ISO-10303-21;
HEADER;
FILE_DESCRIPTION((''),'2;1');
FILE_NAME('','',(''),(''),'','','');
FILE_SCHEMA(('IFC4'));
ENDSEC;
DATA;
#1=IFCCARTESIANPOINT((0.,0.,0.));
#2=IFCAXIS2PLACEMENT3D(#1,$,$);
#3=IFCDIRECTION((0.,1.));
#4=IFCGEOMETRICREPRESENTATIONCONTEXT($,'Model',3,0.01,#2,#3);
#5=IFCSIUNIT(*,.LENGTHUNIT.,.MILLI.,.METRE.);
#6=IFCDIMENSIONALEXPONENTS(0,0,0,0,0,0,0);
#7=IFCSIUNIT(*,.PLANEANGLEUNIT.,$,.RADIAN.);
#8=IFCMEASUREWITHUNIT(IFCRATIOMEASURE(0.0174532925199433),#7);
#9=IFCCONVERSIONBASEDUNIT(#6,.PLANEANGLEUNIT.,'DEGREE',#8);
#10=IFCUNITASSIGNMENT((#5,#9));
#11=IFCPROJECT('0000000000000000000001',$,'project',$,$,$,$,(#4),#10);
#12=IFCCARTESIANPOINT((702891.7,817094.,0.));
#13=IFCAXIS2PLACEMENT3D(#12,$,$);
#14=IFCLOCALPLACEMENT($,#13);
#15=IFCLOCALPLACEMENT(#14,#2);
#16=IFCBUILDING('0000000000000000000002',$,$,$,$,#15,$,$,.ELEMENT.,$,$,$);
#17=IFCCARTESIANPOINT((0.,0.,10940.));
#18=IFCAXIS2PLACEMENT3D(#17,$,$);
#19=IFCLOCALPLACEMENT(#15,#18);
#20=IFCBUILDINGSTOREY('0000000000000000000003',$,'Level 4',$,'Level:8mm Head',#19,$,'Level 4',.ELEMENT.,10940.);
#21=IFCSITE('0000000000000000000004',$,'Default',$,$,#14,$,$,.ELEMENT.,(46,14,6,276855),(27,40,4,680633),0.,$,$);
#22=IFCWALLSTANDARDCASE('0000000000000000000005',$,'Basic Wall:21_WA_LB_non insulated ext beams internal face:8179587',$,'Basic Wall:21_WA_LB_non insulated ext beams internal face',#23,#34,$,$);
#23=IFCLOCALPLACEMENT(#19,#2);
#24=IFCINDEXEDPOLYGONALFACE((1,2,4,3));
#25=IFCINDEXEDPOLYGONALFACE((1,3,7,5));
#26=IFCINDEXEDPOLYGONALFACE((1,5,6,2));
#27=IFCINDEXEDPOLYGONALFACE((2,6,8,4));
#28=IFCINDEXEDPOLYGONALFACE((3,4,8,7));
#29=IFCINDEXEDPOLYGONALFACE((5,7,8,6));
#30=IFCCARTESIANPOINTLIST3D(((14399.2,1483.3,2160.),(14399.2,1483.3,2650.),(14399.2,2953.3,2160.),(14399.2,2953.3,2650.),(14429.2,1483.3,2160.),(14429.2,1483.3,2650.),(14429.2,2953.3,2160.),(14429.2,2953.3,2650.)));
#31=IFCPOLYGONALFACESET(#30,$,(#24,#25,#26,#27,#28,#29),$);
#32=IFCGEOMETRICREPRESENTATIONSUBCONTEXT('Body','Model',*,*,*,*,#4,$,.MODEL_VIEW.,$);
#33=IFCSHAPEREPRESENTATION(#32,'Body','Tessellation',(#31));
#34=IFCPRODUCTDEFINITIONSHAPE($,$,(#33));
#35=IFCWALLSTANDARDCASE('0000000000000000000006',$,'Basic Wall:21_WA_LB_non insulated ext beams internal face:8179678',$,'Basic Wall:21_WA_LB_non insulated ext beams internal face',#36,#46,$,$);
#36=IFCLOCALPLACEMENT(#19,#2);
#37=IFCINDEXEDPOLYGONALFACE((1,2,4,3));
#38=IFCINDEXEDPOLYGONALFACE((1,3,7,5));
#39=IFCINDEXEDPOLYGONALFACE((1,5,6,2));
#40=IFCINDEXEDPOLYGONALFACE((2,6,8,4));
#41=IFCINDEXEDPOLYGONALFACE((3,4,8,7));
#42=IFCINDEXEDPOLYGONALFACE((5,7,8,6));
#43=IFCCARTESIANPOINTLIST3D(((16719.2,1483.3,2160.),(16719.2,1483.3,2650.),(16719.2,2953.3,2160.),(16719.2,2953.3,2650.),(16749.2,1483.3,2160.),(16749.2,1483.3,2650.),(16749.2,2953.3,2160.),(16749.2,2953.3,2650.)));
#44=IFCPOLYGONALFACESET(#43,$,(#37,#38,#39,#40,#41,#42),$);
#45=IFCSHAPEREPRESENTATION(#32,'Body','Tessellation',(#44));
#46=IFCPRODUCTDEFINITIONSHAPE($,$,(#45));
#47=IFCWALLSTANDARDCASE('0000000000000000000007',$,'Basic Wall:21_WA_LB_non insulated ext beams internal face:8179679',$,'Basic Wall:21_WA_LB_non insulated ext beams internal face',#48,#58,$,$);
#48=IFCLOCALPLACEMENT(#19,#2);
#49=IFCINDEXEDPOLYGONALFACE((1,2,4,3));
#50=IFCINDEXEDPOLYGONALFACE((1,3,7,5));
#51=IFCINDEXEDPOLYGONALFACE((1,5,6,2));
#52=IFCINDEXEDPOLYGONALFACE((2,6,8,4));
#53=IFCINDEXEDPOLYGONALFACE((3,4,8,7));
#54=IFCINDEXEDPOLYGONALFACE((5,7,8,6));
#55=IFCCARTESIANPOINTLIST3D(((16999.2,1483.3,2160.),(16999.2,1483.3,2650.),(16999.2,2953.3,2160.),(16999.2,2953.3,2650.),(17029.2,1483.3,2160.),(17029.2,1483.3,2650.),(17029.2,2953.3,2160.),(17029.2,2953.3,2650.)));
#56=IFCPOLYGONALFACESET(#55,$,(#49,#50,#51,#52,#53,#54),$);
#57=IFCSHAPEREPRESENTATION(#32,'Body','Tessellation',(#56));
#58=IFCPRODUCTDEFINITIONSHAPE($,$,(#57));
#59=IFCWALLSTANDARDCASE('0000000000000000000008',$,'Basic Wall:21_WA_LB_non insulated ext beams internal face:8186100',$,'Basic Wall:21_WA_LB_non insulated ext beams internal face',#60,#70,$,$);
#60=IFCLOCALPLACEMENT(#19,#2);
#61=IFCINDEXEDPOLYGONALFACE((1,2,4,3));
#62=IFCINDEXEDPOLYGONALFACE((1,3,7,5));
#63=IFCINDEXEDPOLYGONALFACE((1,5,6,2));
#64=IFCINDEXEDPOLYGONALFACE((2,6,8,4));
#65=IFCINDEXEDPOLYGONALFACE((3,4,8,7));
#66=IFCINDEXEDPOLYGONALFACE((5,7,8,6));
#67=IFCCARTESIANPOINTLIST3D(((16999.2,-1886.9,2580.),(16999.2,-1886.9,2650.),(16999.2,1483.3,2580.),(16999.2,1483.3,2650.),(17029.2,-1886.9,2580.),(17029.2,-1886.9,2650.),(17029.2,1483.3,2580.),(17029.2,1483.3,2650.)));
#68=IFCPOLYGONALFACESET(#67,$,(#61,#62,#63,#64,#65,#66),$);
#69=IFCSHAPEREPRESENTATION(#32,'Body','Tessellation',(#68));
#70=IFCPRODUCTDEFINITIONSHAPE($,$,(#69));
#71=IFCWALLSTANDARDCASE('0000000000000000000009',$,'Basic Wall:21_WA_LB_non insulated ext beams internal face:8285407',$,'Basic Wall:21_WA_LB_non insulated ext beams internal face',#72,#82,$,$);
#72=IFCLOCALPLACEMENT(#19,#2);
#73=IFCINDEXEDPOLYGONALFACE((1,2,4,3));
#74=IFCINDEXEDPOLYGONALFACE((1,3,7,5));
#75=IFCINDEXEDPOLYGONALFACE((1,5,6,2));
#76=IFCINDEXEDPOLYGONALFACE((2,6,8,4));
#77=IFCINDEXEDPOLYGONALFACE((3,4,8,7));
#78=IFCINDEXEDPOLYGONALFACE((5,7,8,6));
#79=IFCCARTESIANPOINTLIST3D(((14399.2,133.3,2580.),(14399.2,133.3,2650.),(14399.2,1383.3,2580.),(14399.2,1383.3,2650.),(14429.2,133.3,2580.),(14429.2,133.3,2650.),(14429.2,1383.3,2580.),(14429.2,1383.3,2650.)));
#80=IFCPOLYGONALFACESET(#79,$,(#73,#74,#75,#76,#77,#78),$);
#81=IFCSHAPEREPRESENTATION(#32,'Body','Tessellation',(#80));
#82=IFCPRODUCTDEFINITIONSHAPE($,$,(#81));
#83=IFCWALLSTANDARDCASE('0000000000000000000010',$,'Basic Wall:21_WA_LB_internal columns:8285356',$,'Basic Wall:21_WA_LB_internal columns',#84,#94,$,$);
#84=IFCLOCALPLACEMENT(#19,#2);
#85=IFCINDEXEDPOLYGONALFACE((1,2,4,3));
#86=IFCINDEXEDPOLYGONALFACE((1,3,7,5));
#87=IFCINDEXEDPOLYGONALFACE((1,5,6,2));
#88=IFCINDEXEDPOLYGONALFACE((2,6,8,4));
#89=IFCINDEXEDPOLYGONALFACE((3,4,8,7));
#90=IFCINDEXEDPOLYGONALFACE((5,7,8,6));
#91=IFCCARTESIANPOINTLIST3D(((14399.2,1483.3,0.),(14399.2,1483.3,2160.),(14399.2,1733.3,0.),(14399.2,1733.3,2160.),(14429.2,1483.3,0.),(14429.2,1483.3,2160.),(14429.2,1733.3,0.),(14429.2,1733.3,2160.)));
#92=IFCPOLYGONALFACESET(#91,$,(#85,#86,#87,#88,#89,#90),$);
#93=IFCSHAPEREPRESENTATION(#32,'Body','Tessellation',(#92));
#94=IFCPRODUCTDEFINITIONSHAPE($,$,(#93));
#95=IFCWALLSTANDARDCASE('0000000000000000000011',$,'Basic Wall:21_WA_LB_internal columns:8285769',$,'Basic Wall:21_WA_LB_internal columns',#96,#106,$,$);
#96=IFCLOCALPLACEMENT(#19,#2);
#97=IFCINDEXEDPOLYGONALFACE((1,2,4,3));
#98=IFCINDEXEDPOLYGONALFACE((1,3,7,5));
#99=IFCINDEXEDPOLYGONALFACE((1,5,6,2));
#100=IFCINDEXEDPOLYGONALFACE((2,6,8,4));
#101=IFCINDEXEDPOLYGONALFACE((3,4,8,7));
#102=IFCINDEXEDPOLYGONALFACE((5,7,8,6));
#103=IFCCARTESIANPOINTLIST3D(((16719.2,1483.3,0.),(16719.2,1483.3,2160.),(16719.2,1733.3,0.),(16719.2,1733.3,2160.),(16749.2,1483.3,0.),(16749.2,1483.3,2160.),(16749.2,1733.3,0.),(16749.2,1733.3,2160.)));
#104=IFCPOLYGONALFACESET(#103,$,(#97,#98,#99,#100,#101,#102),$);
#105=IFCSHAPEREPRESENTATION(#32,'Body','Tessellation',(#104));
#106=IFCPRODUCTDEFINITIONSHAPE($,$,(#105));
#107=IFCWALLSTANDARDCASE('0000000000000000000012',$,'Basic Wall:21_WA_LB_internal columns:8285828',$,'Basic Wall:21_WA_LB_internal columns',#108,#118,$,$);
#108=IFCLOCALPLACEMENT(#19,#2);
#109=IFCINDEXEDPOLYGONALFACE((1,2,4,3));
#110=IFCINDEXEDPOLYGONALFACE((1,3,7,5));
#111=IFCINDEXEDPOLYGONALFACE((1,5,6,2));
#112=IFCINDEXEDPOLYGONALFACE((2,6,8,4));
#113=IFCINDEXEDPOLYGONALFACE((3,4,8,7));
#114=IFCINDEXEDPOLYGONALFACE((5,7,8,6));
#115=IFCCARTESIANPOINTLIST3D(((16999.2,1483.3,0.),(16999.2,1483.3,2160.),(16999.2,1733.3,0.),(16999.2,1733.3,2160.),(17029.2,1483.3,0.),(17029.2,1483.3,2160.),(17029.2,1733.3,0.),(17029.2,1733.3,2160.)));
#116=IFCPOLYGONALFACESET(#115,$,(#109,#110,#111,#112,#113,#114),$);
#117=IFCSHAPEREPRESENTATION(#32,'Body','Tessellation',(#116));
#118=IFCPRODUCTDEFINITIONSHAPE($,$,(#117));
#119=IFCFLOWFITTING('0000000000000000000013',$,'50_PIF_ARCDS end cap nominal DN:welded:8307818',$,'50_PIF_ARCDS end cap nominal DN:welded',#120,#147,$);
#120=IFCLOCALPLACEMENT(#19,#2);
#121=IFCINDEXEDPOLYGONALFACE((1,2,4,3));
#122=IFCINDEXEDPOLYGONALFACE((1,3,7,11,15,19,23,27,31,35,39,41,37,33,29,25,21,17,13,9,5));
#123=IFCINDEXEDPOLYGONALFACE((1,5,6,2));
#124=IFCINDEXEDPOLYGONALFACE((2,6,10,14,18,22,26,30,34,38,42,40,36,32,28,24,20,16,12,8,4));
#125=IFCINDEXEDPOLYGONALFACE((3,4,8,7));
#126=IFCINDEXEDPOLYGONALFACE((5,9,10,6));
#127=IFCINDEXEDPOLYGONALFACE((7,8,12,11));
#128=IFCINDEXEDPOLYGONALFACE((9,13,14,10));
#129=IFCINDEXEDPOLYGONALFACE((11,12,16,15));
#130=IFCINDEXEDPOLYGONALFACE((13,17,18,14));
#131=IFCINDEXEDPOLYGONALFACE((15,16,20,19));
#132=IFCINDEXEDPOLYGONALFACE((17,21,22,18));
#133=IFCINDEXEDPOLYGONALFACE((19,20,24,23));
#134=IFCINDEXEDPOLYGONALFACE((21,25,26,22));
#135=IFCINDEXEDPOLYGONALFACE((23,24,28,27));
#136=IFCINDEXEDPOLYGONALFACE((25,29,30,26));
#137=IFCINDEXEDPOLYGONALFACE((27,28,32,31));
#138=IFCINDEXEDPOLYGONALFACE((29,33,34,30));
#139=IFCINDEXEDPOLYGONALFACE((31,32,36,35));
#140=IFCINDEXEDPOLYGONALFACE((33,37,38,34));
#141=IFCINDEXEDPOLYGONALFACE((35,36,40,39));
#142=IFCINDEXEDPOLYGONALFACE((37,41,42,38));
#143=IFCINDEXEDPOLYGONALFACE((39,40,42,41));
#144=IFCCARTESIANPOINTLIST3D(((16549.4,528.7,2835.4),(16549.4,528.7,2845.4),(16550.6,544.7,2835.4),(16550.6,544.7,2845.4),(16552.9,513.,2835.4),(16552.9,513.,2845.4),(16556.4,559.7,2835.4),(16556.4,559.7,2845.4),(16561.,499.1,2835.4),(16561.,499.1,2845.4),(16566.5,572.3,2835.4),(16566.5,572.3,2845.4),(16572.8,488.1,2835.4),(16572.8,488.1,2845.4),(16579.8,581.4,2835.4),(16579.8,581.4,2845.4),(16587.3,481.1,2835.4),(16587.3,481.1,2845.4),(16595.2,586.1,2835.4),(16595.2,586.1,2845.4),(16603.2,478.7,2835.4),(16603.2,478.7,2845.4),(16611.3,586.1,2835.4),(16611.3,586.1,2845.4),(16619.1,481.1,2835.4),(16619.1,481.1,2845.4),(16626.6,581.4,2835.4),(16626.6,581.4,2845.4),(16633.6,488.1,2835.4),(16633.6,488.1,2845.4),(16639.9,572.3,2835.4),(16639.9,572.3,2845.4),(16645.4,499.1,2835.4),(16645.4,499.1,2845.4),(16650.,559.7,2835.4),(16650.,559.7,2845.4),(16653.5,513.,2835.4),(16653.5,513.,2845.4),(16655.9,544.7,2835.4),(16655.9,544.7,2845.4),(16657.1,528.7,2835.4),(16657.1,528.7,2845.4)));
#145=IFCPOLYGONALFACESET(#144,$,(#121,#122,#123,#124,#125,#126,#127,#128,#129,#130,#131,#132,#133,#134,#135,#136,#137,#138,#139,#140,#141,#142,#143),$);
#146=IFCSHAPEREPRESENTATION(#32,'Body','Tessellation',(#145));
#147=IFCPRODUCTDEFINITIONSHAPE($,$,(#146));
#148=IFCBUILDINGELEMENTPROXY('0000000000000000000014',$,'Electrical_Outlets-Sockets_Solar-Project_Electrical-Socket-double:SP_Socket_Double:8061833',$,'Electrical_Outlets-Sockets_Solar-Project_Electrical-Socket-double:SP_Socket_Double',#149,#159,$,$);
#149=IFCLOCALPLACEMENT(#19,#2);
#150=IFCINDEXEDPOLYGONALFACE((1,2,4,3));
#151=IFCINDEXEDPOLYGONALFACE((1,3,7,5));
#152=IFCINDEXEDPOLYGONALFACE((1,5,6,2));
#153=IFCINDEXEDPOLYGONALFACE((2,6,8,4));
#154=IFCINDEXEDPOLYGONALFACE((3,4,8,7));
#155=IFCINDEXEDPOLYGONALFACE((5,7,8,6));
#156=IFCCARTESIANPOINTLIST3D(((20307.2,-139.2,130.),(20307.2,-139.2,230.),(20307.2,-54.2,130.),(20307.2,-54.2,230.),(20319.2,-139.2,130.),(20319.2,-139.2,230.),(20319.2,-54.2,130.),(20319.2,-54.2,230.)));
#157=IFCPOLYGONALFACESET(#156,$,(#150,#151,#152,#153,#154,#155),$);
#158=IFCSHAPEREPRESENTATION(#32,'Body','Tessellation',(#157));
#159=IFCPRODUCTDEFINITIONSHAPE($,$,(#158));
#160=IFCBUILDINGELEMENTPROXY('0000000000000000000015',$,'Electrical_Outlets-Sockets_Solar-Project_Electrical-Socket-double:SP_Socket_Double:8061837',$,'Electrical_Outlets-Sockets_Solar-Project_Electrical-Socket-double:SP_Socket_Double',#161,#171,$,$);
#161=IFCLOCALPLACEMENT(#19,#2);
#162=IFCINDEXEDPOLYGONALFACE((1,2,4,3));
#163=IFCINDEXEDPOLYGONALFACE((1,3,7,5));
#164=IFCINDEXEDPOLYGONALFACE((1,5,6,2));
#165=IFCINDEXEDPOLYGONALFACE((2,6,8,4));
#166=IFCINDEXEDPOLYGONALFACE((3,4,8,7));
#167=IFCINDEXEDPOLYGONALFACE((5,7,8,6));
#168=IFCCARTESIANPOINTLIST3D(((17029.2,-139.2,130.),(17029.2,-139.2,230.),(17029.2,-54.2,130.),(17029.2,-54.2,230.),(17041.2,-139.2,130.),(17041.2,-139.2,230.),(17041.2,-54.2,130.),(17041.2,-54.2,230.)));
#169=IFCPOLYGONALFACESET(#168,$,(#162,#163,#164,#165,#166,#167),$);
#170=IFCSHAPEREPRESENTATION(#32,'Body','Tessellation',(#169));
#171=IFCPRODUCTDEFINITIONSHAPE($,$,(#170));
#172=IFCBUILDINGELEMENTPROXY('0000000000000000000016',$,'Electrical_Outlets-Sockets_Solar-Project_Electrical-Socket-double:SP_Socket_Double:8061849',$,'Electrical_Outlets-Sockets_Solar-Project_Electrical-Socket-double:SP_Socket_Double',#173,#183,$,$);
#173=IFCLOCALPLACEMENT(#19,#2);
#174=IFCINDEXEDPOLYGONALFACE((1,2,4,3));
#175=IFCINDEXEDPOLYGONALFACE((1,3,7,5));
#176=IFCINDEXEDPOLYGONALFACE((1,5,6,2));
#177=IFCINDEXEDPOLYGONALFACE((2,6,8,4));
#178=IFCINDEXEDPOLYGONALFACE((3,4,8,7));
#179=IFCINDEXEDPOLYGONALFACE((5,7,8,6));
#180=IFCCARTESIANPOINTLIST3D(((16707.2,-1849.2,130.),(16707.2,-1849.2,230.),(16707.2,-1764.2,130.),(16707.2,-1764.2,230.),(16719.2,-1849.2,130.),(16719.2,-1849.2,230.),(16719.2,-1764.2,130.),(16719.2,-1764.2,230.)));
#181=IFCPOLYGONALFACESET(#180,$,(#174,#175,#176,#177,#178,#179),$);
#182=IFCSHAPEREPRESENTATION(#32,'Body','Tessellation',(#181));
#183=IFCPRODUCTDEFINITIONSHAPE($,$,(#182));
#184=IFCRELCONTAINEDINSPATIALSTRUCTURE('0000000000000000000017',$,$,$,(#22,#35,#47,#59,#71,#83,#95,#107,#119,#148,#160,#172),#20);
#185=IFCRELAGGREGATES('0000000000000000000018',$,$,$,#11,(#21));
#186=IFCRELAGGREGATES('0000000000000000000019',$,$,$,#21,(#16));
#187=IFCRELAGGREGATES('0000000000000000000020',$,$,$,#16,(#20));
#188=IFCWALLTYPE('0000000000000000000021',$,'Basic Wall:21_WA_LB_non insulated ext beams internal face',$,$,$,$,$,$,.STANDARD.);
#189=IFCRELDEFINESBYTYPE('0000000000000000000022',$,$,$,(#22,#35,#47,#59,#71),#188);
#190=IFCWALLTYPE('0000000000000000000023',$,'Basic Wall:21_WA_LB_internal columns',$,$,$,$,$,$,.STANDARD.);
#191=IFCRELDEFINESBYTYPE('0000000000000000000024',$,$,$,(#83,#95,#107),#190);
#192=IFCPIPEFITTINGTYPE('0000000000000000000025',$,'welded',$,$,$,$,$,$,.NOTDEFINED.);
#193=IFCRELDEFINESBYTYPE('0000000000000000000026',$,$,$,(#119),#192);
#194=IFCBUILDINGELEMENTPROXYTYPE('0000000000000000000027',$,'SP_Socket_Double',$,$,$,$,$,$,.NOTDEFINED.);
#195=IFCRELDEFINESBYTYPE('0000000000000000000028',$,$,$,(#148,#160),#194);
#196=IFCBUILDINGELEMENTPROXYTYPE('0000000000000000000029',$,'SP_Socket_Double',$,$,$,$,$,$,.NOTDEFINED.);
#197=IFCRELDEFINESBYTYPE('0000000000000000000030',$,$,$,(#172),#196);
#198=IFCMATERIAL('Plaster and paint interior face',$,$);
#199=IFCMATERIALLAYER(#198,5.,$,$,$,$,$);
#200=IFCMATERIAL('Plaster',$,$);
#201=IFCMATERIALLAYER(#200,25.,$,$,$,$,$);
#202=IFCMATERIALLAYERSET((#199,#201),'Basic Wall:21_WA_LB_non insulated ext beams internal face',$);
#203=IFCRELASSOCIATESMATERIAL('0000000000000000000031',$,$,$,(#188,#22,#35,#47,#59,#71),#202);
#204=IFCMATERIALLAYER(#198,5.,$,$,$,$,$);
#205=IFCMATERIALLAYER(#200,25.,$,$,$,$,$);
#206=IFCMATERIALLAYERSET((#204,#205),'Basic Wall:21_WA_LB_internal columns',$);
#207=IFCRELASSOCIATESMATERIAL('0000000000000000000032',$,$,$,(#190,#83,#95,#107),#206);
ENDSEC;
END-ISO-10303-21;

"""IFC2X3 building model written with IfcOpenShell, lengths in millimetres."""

from ifc_helpers import new_model, entity, si_unit, converted_unit, direction, frame, frame_2d, origin, origin_2d_with_axis, place, context, subcontext, project, spatial, rectangle, circle, extrude, source, transform, mapped, material, layer, layer_set, layer_usage, type_object, type_shapes, element, save


model = new_model("IFC2X3")

# Units and contexts
model_context = context("Model", 3, precision=0.01, world=origin(), true_north=direction((0.0, 1.0)))
body_context = subcontext(model_context, "Body", "Model", "MODEL_VIEW")
ifc_project = project(units=[si_unit("LENGTHUNIT", "METRE", prefix="MILLI"), converted_unit("PLANEANGLEUNIT", "DEGREE", entity("IfcRatioMeasure", 0.0174532925199433), si_unit("PLANEANGLEUNIT", "RADIAN"), dimensions=[0, 0, 0, 0, 0, 0, 0])], contexts=[model_context])

# Site, building, storey
site_placement = place(None, frame((702891.7, 817094.0, 0.0)))
site = spatial("IfcSite", under=ifc_project, at=site_placement, Name="Default", CompositionType="ELEMENT", RefLatitude=(46, 14, 6, 276855), RefLongitude=(27, 40, 4, 680633), RefElevation=0.0)
building_placement = place(site_placement, origin())
building = spatial("IfcBuilding", under=site, at=building_placement, CompositionType="ELEMENT")
storey_placement = place(building_placement, frame((0.0, 0.0, 10940.0)))
storey = spatial("IfcBuildingStorey", under=building, at=storey_placement, Name="Level 4", ObjectType="Level:8mm Head", LongName="Level 4", CompositionType="ELEMENT", Elevation=10940.0)

# Shared definitions
ifc_material_1 = material(Name="Plaster and paint interior face")
ifc_material_2 = material(Name="Plaster")

# Walls
ifc_layer_1 = layer(ifc_material_1, 5.0)
ifc_layer_2 = layer(ifc_material_2, 25.0)
ifc_layer_set_1 = layer_set([ifc_layer_1, ifc_layer_2], Name="Basic Wall:21_WA_LB_non insulated ext beams internal face")
wall_type_1 = type_object("IfcWallType", Name="Basic Wall:21_WA_LB_non insulated ext beams internal face", PredefinedType="STANDARD", material=ifc_layer_set_1)
ifc_layer_usage_1 = layer_usage(ifc_layer_set_1, "AXIS2", "POSITIVE", -15.0)
wall_1_placement = place(storey_placement, frame((14414.2, 1483.3, 2160.0), z_axis=(0.0, 0.0, 1.0), x_axis=(0.0, 1.0, 0.0)))
element("IfcWallStandardCase", 1, at=wall_1_placement, inside=storey, type_object=wall_type_1, material=ifc_layer_usage_1, Name="Basic Wall:21_WA_LB_non insulated ext beams internal face:8179587", ObjectType="Basic Wall:21_WA_LB_non insulated ext beams internal face", context=body_context, shape_type="SweptSolid", body=[
    extrude(rectangle(XDim=1470.0, YDim=30.0, at=frame_2d((735.0, 0.0), x_axis=(-1.0, 0.0))), origin(), (0.0, 0.0, 1.0), 490.0),
])
ifc_layer_usage_2 = layer_usage(ifc_layer_set_1, "AXIS2", "NEGATIVE", 15.0)
wall_2_placement = place(storey_placement, frame((16734.2, 1483.3, 2160.0), z_axis=(0.0, 0.0, 1.0), x_axis=(0.0, 1.0, 0.0)))
element("IfcWallStandardCase", 2, at=wall_2_placement, inside=storey, type_object=wall_type_1, material=ifc_layer_usage_2, Name="Basic Wall:21_WA_LB_non insulated ext beams internal face:8179678", ObjectType="Basic Wall:21_WA_LB_non insulated ext beams internal face", context=body_context, shape_type="SweptSolid", body=[
    extrude(rectangle(XDim=1470.0, YDim=30.0, at=frame_2d((735.0, 0.0), x_axis=(-1.0, 0.0))), origin(), (0.0, 0.0, 1.0), 490.0),
])
ifc_layer_usage_3 = layer_usage(ifc_layer_set_1, "AXIS2", "POSITIVE", -15.0)
wall_3_placement = place(storey_placement, frame((17014.2, 1483.3, 2160.0), z_axis=(0.0, 0.0, 1.0), x_axis=(0.0, 1.0, 0.0)))
element("IfcWallStandardCase", 3, at=wall_3_placement, inside=storey, type_object=wall_type_1, material=ifc_layer_usage_3, Name="Basic Wall:21_WA_LB_non insulated ext beams internal face:8179679", ObjectType="Basic Wall:21_WA_LB_non insulated ext beams internal face", context=body_context, shape_type="SweptSolid", body=[
    extrude(rectangle(XDim=1470.0, YDim=30.0, at=frame_2d((735.0, 0.0), x_axis=(-1.0, 0.0))), origin(), (0.0, 0.0, 1.0), 490.0),
])
ifc_layer_usage_4 = layer_usage(ifc_layer_set_1, "AXIS2", "NEGATIVE", 15.0)
wall_4_placement = place(storey_placement, frame((17014.2, 1483.3, 2580.0), z_axis=(0.0, 0.0, 1.0), x_axis=(0.0, -1.0, 0.0)))
element("IfcWallStandardCase", 4, at=wall_4_placement, inside=storey, type_object=wall_type_1, material=ifc_layer_usage_4, Name="Basic Wall:21_WA_LB_non insulated ext beams internal face:8186100", ObjectType="Basic Wall:21_WA_LB_non insulated ext beams internal face", context=body_context, shape_type="SweptSolid", body=[
    extrude(rectangle(XDim=3370.2, YDim=30.0, at=frame_2d((1685.1, 0.0), x_axis=(-1.0, 0.0))), origin(), (0.0, 0.0, 1.0), 70.0),
])
ifc_layer_usage_5 = layer_usage(ifc_layer_set_1, "AXIS2", "POSITIVE", -15.0)
wall_5_placement = place(storey_placement, frame((14414.2, 133.3, 2580.0), z_axis=(0.0, 0.0, 1.0), x_axis=(0.0, 1.0, 0.0)))
element("IfcWallStandardCase", 5, at=wall_5_placement, inside=storey, type_object=wall_type_1, material=ifc_layer_usage_5, Name="Basic Wall:21_WA_LB_non insulated ext beams internal face:8285407", ObjectType="Basic Wall:21_WA_LB_non insulated ext beams internal face", context=body_context, shape_type="SweptSolid", body=[
    extrude(rectangle(XDim=1250.0, YDim=30.0, at=frame_2d((625.0, 0.0), x_axis=(-1.0, 0.0))), origin(), (0.0, 0.0, 1.0), 70.0),
])
ifc_layer_3 = layer(ifc_material_1, 5.0)
ifc_layer_4 = layer(ifc_material_2, 25.0)
ifc_layer_set_2 = layer_set([ifc_layer_3, ifc_layer_4], Name="Basic Wall:21_WA_LB_internal columns")
ifc_layer_usage_6 = layer_usage(ifc_layer_set_2, "AXIS2", "NEGATIVE", 15.0)
wall_type_2 = type_object("IfcWallType", Name="Basic Wall:21_WA_LB_internal columns", PredefinedType="STANDARD", material=ifc_layer_set_2)
wall_6_placement = place(storey_placement, frame((14414.2, 1733.3, 0.0), z_axis=(0.0, 0.0, 1.0), x_axis=(0.0, -1.0, 0.0)))
element("IfcWallStandardCase", 6, at=wall_6_placement, inside=storey, type_object=wall_type_2, material=ifc_layer_usage_6, Name="Basic Wall:21_WA_LB_internal columns:8285356", ObjectType="Basic Wall:21_WA_LB_internal columns", context=body_context, shape_type="SweptSolid", body=[
    extrude(rectangle(XDim=250.0, YDim=30.0, at=frame_2d((125.0, 0.0), x_axis=(-1.0, 0.0))), origin(), (0.0, 0.0, 1.0), 2160.0),
])
ifc_layer_usage_7 = layer_usage(ifc_layer_set_2, "AXIS2", "POSITIVE", -15.0)
wall_7_placement = place(storey_placement, frame((16734.2, 1733.3, 0.0), z_axis=(0.0, 0.0, 1.0), x_axis=(0.0, -1.0, 0.0)))
element("IfcWallStandardCase", 7, at=wall_7_placement, inside=storey, type_object=wall_type_2, material=ifc_layer_usage_7, Name="Basic Wall:21_WA_LB_internal columns:8285769", ObjectType="Basic Wall:21_WA_LB_internal columns", context=body_context, shape_type="SweptSolid", body=[
    extrude(rectangle(XDim=250.0, YDim=30.0, at=frame_2d((125.0, 0.0), x_axis=(-1.0, 0.0))), origin(), (0.0, 0.0, 1.0), 2160.0),
])
ifc_layer_usage_8 = layer_usage(ifc_layer_set_2, "AXIS2", "NEGATIVE", 15.0)
wall_8_placement = place(storey_placement, frame((17014.2, 1733.3, 0.0), z_axis=(0.0, 0.0, 1.0), x_axis=(0.0, -1.0, 0.0)))
element("IfcWallStandardCase", 8, at=wall_8_placement, inside=storey, type_object=wall_type_2, material=ifc_layer_usage_8, Name="Basic Wall:21_WA_LB_internal columns:8285828", ObjectType="Basic Wall:21_WA_LB_internal columns", context=body_context, shape_type="SweptSolid", body=[
    extrude(rectangle(XDim=250.0, YDim=30.0, at=frame_2d((125.0, 0.0), x_axis=(-1.0, 0.0))), origin(), (0.0, 0.0, 1.0), 2160.0),
])

# Flow fitting
pipe_fitting_type = type_object("IfcPipeFittingType", Name="welded", PredefinedType="NOTDEFINED")
shared_shape_1 = source(origin(), body_context, "Body", "SweptSolid", [
    extrude(circle(Radius=54.0, at=frame_2d((0.0, 0.0), x_axis=(1.0, 0.0))), frame((0.0, 0.0, 0.0), z_axis=(1.0, 0.0, 0.0), x_axis=(0.0, 1.0, 0.0)), (0.0, 0.0, 1.0), 10.0),
])
type_shapes(pipe_fitting_type, [shared_shape_1])
flow_fitting_placement = place(storey_placement, frame((16603.2, 532.7, 2835.4), z_axis=(1.0, 0.0, 0.0), x_axis=(0.0, 0.0, 1.0)))
element("IfcFlowFitting", 9, at=flow_fitting_placement, inside=storey, type_object=pipe_fitting_type, Name="50_PIF_ARCDS end cap nominal DN:welded:8307818", ObjectType="50_PIF_ARCDS end cap nominal DN:welded", context=body_context, shape_type="MappedRepresentation", body=[
    mapped(shared_shape_1, transform((0.0, 0.0, 0.0), scale=1.0)),
])

# Building element proxies
building_element_proxy_type_1 = type_object("IfcBuildingElementProxyType", Name="SP_Socket_Double", PredefinedType="NOTDEFINED")
shared_shape_2 = source(origin(), body_context, "Body", "SweptSolid", [
    extrude(rectangle(XDim=85.0, YDim=12.0, at=origin_2d_with_axis()), frame((0.0, 6.0, -100.0), z_axis=(0.0, 0.0, 1.0), x_axis=(-1.0, 0.0, 0.0)), (0.0, 0.0, 1.0), 100.0),
])
type_shapes(building_element_proxy_type_1, [shared_shape_2])
for number, where, z_axis, x_axis, name in (
    (10, (20319.2, -96.7, 230.0), (0.0, 0.0, 1.0), (0.0, 1.0, 0.0), "Electrical_Outlets-Sockets_Solar-Project_Electrical-Socket-double:SP_Socket_Double:8061833"),
    (11, (17029.2, -96.7, 230.0), (0.0, 0.0, 1.0), (0.0, -1.0, 0.0), "Electrical_Outlets-Sockets_Solar-Project_Electrical-Socket-double:SP_Socket_Double:8061837"),
):
    element("IfcBuildingElementProxy", number, at=place(storey_placement, frame(where, z_axis=z_axis, x_axis=x_axis)), inside=storey, type_object=building_element_proxy_type_1, Name=name, ObjectType="Electrical_Outlets-Sockets_Solar-Project_Electrical-Socket-double:SP_Socket_Double", context=body_context, shape_type="MappedRepresentation", body=[
        mapped(shared_shape_2, transform((0.0, 0.0, 0.0), scale=1.0)),
    ])
building_element_proxy_type_2 = type_object("IfcBuildingElementProxyType", Name="SP_Socket_Double", PredefinedType="NOTDEFINED")
shared_shape_3 = source(origin(), body_context, "Body", "SweptSolid", [
    extrude(rectangle(XDim=12.0, YDim=85.0, at=origin_2d_with_axis()), frame((0.0, -6.0, -100.0), z_axis=(0.0, 0.0, 1.0), x_axis=(0.0, 1.0, 0.0)), (0.0, 0.0, 1.0), 100.0),
])
type_shapes(building_element_proxy_type_2, [shared_shape_3])
proxy_1_placement = place(storey_placement, frame((16719.2, -1806.7, 230.0), z_axis=(0.0, 0.0, 1.0), x_axis=(0.0, -1.0, 0.0)))
element("IfcBuildingElementProxy", 12, at=proxy_1_placement, inside=storey, type_object=building_element_proxy_type_2, Name="Electrical_Outlets-Sockets_Solar-Project_Electrical-Socket-double:SP_Socket_Double:8061849", ObjectType="Electrical_Outlets-Sockets_Solar-Project_Electrical-Socket-double:SP_Socket_Double", context=body_context, shape_type="MappedRepresentation", body=[
    mapped(shared_shape_3, transform((0.0, 0.0, 0.0), scale=1.0)),
])

save(model, "model.ifc")
